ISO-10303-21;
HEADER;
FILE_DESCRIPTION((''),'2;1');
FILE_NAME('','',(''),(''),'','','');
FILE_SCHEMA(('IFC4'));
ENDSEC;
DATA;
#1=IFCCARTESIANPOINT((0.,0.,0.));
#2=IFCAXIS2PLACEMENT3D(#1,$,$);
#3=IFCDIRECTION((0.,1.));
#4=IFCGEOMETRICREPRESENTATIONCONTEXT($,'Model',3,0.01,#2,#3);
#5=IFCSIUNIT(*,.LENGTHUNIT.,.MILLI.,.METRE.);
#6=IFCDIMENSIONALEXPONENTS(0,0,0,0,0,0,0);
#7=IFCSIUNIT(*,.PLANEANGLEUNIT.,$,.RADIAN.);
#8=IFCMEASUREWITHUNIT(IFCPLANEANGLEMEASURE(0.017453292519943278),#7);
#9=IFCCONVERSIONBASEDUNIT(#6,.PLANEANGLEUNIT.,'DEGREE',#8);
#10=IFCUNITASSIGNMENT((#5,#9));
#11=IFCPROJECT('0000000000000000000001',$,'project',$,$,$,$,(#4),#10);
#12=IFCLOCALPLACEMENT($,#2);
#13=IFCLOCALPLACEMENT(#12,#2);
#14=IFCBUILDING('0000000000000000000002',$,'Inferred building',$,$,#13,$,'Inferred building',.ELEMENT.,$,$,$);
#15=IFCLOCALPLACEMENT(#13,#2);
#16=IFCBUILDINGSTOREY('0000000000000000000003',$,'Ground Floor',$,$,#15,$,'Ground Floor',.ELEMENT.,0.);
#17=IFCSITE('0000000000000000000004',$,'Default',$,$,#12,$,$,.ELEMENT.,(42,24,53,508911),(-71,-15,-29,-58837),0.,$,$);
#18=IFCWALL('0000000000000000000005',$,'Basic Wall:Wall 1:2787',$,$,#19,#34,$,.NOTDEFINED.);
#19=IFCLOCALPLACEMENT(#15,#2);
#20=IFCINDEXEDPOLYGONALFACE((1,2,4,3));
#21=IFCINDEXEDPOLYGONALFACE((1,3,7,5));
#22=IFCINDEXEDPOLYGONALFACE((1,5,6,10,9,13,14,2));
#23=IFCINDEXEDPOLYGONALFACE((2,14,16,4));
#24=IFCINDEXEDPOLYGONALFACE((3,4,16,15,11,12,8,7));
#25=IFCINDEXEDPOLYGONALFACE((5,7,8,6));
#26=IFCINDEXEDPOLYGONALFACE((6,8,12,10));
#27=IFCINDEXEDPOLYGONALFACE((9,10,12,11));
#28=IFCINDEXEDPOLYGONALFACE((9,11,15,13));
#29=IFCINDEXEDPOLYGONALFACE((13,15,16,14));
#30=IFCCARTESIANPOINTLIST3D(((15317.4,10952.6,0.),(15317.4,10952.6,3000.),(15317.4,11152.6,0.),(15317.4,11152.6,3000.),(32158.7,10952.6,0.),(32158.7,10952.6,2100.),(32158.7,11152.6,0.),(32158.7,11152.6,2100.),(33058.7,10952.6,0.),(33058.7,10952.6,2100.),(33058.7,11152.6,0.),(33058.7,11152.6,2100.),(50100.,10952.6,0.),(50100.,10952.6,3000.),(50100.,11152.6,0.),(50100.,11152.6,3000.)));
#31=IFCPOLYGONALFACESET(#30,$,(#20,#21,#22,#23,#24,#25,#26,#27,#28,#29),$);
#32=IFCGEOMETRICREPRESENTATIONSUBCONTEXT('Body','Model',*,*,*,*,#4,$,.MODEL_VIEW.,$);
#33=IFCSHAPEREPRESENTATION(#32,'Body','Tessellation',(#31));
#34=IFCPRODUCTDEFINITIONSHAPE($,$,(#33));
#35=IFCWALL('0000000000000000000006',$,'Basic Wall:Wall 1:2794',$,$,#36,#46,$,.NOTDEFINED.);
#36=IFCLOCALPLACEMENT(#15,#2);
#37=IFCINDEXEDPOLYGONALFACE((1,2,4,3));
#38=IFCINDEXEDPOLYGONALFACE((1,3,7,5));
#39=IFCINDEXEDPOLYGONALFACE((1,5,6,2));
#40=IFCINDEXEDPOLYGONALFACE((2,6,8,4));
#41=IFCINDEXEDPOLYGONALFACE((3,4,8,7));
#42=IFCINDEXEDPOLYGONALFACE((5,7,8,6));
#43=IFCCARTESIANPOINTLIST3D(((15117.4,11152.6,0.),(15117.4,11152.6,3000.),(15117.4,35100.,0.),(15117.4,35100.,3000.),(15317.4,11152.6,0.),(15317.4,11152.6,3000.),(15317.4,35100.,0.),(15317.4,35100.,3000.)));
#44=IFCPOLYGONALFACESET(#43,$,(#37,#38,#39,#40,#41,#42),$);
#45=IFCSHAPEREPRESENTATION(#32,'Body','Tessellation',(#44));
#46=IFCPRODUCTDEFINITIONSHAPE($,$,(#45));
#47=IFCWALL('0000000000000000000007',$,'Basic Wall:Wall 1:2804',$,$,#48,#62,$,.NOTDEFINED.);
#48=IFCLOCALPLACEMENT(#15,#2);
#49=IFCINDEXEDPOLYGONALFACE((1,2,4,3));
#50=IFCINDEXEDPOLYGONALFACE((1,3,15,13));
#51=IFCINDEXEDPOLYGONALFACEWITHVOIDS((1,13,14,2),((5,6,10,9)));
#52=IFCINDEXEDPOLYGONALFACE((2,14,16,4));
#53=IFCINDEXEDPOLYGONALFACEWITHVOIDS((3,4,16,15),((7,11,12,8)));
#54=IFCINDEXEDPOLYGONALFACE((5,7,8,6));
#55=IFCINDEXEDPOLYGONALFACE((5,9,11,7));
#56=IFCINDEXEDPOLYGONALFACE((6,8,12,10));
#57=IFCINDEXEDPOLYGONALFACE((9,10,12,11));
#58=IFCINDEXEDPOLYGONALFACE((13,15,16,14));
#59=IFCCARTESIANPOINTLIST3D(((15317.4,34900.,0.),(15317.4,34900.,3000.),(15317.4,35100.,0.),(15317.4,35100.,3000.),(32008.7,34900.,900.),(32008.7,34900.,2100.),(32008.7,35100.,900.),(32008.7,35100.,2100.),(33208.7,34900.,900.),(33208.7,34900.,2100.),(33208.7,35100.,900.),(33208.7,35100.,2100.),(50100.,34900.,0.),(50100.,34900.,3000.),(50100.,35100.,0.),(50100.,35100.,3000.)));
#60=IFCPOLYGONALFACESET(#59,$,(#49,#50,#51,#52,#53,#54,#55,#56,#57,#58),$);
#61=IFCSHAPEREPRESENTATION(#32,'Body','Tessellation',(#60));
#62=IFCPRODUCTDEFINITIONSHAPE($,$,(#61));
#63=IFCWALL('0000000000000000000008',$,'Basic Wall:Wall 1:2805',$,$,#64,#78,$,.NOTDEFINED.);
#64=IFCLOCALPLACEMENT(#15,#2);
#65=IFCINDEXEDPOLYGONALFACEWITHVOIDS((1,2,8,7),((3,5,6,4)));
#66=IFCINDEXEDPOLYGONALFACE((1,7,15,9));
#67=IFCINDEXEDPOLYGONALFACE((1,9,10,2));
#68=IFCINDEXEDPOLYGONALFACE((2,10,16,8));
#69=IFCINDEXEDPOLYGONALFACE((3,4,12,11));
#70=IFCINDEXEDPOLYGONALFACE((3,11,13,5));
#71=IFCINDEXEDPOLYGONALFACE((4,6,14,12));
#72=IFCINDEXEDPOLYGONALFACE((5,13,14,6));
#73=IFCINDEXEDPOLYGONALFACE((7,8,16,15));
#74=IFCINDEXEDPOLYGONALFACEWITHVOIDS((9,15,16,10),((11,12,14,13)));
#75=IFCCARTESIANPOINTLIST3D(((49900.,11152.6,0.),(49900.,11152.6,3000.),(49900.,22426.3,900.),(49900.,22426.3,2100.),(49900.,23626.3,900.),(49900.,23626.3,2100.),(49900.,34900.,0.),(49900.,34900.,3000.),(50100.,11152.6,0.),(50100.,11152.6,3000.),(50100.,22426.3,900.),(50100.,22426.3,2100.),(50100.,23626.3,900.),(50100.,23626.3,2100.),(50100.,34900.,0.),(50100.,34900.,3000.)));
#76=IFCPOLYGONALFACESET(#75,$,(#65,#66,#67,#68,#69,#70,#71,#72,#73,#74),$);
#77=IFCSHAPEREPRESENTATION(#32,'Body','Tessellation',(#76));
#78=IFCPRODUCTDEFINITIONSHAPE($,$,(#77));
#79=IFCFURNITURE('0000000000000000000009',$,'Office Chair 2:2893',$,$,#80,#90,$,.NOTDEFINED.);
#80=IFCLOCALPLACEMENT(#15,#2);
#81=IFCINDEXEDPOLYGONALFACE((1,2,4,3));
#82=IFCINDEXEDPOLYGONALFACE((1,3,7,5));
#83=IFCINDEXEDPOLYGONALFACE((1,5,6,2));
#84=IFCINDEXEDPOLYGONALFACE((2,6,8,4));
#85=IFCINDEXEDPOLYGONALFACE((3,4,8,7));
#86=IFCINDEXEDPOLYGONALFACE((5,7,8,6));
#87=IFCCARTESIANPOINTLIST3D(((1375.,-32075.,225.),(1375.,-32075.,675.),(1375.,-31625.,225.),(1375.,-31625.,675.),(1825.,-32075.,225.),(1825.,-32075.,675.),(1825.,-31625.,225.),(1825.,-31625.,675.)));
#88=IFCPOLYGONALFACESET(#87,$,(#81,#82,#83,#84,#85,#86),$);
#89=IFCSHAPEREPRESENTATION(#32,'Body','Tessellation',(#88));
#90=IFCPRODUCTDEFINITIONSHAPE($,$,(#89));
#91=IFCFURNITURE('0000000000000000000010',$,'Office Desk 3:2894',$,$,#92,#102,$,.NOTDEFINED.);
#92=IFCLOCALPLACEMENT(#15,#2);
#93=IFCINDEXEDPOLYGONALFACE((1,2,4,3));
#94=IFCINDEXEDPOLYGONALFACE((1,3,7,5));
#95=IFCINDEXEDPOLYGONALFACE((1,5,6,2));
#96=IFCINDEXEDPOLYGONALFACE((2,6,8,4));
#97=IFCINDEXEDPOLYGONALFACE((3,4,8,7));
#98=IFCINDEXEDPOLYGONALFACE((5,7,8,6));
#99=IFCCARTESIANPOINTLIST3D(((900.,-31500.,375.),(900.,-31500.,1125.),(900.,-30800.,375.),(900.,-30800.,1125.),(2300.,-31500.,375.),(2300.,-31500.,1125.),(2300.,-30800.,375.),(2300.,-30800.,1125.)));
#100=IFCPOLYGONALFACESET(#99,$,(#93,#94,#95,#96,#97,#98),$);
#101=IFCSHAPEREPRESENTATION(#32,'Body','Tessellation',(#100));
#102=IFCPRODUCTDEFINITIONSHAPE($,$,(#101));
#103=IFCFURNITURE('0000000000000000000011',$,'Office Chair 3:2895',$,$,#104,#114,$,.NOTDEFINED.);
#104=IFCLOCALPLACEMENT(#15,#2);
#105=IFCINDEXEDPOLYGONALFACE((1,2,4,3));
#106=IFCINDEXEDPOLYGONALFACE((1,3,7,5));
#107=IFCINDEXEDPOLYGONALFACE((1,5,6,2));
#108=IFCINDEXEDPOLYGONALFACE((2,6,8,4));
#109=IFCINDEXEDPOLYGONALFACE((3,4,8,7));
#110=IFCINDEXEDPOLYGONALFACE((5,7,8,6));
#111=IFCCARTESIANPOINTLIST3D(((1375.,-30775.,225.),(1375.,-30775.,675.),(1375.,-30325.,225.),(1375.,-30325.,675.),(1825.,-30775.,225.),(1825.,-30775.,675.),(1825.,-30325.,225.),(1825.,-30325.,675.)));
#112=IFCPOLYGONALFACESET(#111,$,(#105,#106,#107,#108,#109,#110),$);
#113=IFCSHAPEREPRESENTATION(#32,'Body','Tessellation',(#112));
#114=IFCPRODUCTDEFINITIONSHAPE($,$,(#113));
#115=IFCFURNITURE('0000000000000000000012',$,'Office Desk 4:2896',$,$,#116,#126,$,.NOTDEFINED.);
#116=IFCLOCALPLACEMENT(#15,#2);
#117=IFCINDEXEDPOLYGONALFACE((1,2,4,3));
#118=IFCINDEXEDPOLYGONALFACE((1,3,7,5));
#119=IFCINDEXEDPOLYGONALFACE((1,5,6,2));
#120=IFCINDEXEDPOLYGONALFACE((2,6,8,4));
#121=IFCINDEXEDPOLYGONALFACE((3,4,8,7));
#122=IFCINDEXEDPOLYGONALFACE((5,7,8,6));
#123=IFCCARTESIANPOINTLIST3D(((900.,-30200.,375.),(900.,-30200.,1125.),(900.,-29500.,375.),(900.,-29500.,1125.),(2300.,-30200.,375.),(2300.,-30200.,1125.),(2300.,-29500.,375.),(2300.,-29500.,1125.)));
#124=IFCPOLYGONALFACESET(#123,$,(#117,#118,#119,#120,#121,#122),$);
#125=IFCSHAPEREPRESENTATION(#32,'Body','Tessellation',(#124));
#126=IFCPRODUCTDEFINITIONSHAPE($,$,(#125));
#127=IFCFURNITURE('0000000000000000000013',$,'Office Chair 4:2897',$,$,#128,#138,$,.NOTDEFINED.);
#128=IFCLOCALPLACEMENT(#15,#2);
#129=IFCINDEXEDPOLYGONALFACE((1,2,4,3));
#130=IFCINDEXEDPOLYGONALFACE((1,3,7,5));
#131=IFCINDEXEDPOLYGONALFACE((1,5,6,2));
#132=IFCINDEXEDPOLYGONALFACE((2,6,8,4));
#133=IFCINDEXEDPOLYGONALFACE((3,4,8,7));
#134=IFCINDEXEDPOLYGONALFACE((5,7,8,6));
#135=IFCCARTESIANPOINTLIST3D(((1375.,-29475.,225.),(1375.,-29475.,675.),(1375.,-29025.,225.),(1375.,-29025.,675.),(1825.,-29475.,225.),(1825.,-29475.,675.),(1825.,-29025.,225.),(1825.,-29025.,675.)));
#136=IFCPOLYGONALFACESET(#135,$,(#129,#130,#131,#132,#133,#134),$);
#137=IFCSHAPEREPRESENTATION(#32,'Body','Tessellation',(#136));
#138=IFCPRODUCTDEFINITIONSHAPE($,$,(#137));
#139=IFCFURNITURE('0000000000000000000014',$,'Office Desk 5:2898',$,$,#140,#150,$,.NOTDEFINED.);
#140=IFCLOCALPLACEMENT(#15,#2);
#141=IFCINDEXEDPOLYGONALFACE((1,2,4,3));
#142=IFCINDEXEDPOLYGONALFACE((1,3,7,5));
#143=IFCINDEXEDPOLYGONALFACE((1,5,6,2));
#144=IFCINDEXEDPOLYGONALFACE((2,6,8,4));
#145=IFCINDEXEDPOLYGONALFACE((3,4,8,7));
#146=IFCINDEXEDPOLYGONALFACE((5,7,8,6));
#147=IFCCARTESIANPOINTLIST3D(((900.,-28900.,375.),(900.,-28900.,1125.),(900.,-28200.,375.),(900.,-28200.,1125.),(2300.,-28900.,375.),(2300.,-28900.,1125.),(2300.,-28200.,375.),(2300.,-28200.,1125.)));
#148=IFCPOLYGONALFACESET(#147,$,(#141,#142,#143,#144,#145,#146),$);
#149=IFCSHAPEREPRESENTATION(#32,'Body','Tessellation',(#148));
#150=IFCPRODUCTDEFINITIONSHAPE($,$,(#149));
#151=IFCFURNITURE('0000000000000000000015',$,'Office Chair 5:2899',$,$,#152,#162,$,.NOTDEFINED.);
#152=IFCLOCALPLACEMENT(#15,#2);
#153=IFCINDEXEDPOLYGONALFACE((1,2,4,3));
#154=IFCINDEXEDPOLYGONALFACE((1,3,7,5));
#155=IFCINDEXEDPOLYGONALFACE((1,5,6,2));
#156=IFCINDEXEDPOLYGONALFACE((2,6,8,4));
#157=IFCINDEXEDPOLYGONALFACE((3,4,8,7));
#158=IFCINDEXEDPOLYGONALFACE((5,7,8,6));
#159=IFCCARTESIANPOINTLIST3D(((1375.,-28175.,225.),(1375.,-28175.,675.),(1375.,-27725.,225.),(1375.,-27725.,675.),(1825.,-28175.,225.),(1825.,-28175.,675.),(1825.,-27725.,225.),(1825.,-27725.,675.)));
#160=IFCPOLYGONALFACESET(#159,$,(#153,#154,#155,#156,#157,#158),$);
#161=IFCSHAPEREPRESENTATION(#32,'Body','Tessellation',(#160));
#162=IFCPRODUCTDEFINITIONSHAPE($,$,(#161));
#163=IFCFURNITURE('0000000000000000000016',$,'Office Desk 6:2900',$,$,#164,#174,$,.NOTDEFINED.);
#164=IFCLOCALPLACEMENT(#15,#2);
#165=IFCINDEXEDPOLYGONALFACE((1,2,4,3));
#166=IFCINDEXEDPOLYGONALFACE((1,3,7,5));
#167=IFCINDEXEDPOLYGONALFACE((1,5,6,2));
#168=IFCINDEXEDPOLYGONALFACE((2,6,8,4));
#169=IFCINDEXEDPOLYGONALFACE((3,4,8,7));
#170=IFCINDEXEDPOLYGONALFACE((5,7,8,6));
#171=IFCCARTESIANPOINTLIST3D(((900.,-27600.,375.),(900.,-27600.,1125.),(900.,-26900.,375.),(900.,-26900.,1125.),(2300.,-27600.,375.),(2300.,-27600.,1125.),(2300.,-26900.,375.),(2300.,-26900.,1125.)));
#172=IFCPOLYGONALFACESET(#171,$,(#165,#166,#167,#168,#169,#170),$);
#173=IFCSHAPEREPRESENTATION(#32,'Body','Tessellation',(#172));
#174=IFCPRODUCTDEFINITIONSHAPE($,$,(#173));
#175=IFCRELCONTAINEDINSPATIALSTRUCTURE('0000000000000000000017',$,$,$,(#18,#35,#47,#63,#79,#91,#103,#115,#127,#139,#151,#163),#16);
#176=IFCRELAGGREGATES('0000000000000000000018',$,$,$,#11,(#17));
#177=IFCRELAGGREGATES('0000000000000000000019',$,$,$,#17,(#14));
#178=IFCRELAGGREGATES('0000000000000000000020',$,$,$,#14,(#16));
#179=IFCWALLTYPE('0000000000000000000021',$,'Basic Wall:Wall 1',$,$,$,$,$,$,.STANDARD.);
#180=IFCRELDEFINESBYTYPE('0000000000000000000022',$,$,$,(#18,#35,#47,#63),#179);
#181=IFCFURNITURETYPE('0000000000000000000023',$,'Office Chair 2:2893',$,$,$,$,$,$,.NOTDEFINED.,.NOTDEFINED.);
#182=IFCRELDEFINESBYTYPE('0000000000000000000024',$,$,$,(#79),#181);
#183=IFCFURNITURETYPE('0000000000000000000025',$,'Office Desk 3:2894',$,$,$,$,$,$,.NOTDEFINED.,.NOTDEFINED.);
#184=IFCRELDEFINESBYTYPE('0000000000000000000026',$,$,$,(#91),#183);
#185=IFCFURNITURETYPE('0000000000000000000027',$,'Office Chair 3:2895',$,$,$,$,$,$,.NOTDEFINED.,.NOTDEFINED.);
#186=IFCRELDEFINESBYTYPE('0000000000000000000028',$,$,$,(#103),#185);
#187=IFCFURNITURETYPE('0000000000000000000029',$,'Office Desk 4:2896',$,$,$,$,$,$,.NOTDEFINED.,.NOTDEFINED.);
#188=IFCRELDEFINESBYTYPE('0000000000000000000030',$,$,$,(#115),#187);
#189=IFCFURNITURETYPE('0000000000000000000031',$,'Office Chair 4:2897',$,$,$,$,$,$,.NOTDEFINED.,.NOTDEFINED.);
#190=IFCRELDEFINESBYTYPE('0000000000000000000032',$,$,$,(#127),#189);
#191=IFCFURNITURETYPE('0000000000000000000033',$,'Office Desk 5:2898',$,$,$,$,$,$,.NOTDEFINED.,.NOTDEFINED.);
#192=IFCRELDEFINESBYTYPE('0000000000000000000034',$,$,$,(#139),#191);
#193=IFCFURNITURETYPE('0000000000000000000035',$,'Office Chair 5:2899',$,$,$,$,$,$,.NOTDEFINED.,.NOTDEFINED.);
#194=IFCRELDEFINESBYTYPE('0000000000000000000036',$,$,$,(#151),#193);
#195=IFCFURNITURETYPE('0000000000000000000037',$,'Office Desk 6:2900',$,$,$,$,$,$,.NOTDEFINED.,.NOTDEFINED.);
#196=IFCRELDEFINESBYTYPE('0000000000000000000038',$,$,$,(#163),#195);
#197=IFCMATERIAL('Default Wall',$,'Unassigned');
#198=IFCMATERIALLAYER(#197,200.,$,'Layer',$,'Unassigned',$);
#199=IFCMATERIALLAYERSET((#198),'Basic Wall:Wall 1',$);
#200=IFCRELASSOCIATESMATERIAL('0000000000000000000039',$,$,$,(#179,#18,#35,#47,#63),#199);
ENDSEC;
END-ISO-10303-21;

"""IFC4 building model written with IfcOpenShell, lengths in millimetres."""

from ifc_helpers import new_model, entity, si_unit, converted_unit, direction, frame, frame_2d, origin, origin_2d_with_axis, place, context, subcontext, project, spatial, rectangle, extrude, material, layer, layer_set, layer_usage, type_object, element, save


model = new_model("IFC4")

# Units and contexts
model_context = context("Model", 3, precision=0.01, world=origin(), true_north=direction((0.0, 1.0)))
body_context = subcontext(model_context, "Body", "Model", "MODEL_VIEW")
ifc_project = project(units=[si_unit("LENGTHUNIT", "METRE", prefix="MILLI"), converted_unit("PLANEANGLEUNIT", "DEGREE", entity("IfcPlaneAngleMeasure", 0.017453292519943278), si_unit("PLANEANGLEUNIT", "RADIAN"), dimensions=[0, 0, 0, 0, 0, 0, 0])], contexts=[model_context])

# Site, building, storey
site_placement = place(None, origin())
site = spatial("IfcSite", under=ifc_project, at=site_placement, Name="Default", CompositionType="ELEMENT", RefLatitude=(42, 24, 53, 508911), RefLongitude=(-71, -15, -29, -58837), RefElevation=0.0)
building_placement = place(site_placement, origin())
building = spatial("IfcBuilding", under=site, at=building_placement, Name="Inferred building", LongName="Inferred building", CompositionType="ELEMENT")
storey_placement = place(building_placement, origin())
storey = spatial("IfcBuildingStorey", under=building, at=storey_placement, Name="Ground Floor", LongName="Ground Floor", CompositionType="ELEMENT", Elevation=0.0)

# Wall, opening
ifc_material = material(Name="Default Wall", Category="Unassigned")
ifc_layer = layer(ifc_material, 200.0, Name="Layer", Category="Unassigned")
ifc_layer_set = layer_set([ifc_layer], Name="Basic Wall:Wall 1")
ifc_layer_usage_1 = layer_usage(ifc_layer_set, "AXIS2", "NEGATIVE", 100.0)
wall_type = type_object("IfcWallType", Name="Basic Wall:Wall 1", PredefinedType="STANDARD", material=ifc_layer_set)
wall_1_placement = place(storey_placement, frame((15317.4, 11052.6, 0.0)))
wall_1 = element("IfcWall", 1, at=wall_1_placement, inside=storey, type_object=wall_type, material=ifc_layer_usage_1, Name="Basic Wall:Wall 1:2787", PredefinedType="NOTDEFINED", context=body_context, shape_type="SweptSolid", body=[
    extrude(rectangle(XDim=34782.6, YDim=200.0, at=frame_2d((17391.3, 0.0), x_axis=(1.0, 0.0))), origin(), (0.0, 0.0, 1.0), 3000.0),
])
opening_1_placement = place(wall_1_placement, origin())
element("IfcOpeningElement", 2, at=opening_1_placement, cuts=wall_1, PredefinedType="OPENING", context=body_context, shape_type="SweptSolid", body=[
    extrude(rectangle(XDim=2100.0, YDim=900.0, at=frame_2d((0.0, 0.0), x_axis=(1.0, 0.0))), frame((17291.3, -100.0, 1050.0), z_axis=(0.0, 1.0, 0.0), x_axis=(0.0, 0.0, -1.0)), (0.0, 0.0, 1.0), 200.0),
])

# Wall
ifc_layer_usage_2 = layer_usage(ifc_layer_set, "AXIS2", "NEGATIVE", 100.0)
wall_2_placement = place(storey_placement, frame((15217.4, 11152.6, 0.0), z_axis=(0.0, 0.0, 1.0), x_axis=(0.0, 1.0, 0.0)))
element("IfcWall", 3, at=wall_2_placement, inside=storey, type_object=wall_type, material=ifc_layer_usage_2, Name="Basic Wall:Wall 1:2794", PredefinedType="NOTDEFINED", context=body_context, shape_type="SweptSolid", body=[
    extrude(rectangle(XDim=23947.4, YDim=200.0, at=frame_2d((11973.7, 0.0), x_axis=(-1.0, 0.0))), origin(), (0.0, 0.0, 1.0), 3000.0),
])

# Walls, openings
ifc_layer_usage_3 = layer_usage(ifc_layer_set, "AXIS2", "NEGATIVE", 100.0)
wall_3_placement = place(storey_placement, frame((15317.4, 35000.0, 0.0)))
wall_3 = element("IfcWall", 4, at=wall_3_placement, inside=storey, type_object=wall_type, material=ifc_layer_usage_3, Name="Basic Wall:Wall 1:2804", PredefinedType="NOTDEFINED", context=body_context, shape_type="SweptSolid", body=[
    extrude(rectangle(XDim=34782.6, YDim=200.0, at=frame_2d((17391.3, 0.0), x_axis=(-1.0, 0.0))), origin(), (0.0, 0.0, 1.0), 3000.0),
])
opening_2_placement = place(wall_3_placement, origin())
element("IfcOpeningElement", 5, at=opening_2_placement, cuts=wall_3, PredefinedType="OPENING", context=body_context, shape_type="SweptSolid", body=[
    extrude(rectangle(XDim=1200.0, YDim=1200.0, at=frame_2d((0.0, 0.0), x_axis=(1.0, 0.0))), frame((17291.3, -100.0, 1500.0), z_axis=(0.0, 1.0, 0.0), x_axis=(0.0, 0.0, -1.0)), (0.0, 0.0, 1.0), 200.0),
])
ifc_layer_usage_4 = layer_usage(ifc_layer_set, "AXIS2", "NEGATIVE", 100.0)
wall_4_placement = place(storey_placement, frame((50000.0, 11152.6, 0.0), z_axis=(0.0, 0.0, 1.0), x_axis=(0.0, 1.0, 0.0)))
wall_4 = element("IfcWall", 6, at=wall_4_placement, inside=storey, type_object=wall_type, material=ifc_layer_usage_4, Name="Basic Wall:Wall 1:2805", PredefinedType="NOTDEFINED", context=body_context, shape_type="SweptSolid", body=[
    extrude(rectangle(XDim=23747.4, YDim=200.0, at=frame_2d((11873.7, 0.0), x_axis=(-1.0, 0.0))), origin(), (0.0, 0.0, 1.0), 3000.0),
])
opening_3_placement = place(wall_4_placement, origin())
element("IfcOpeningElement", 7, at=opening_3_placement, cuts=wall_4, PredefinedType="OPENING", context=body_context, shape_type="SweptSolid", body=[
    extrude(rectangle(XDim=1200.0, YDim=1200.0, at=frame_2d((0.0, 0.0), x_axis=(1.0, 0.0))), frame((11873.7, -100.0, 1500.0), z_axis=(0.0, 1.0, 0.0), x_axis=(0.0, 0.0, -1.0)), (0.0, 0.0, 1.0), 200.0),
])

# Furniture
furniture_type_1 = type_object("IfcFurnitureType", Name="Office Chair 2:2893", PredefinedType="NOTDEFINED")
furniture_1_placement = place(storey_placement, origin())
element("IfcFurniture", 8, at=furniture_1_placement, inside=storey, type_object=furniture_type_1, Name="Office Chair 2:2893", PredefinedType="NOTDEFINED", context=body_context, shape_type="SweptSolid", body=[
    extrude(rectangle(XDim=450.0, YDim=450.0, at=origin_2d_with_axis()), frame((1600.0, -31850.0, 225.0)), (0.0, 0.0, 1.0), 450.0),
])
furniture_type_2 = type_object("IfcFurnitureType", Name="Office Desk 3:2894", PredefinedType="NOTDEFINED")
furniture_2_placement = place(storey_placement, origin())
element("IfcFurniture", 9, at=furniture_2_placement, inside=storey, type_object=furniture_type_2, Name="Office Desk 3:2894", PredefinedType="NOTDEFINED", context=body_context, shape_type="SweptSolid", body=[
    extrude(rectangle(XDim=1400.0, YDim=700.0, at=origin_2d_with_axis()), frame((1600.0, -31150.0, 375.0)), (0.0, 0.0, 1.0), 750.0),
])
furniture_type_3 = type_object("IfcFurnitureType", Name="Office Chair 3:2895", PredefinedType="NOTDEFINED")
furniture_3_placement = place(storey_placement, origin())
element("IfcFurniture", 10, at=furniture_3_placement, inside=storey, type_object=furniture_type_3, Name="Office Chair 3:2895", PredefinedType="NOTDEFINED", context=body_context, shape_type="SweptSolid", body=[
    extrude(rectangle(XDim=450.0, YDim=450.0, at=origin_2d_with_axis()), frame((1600.0, -30550.0, 225.0)), (0.0, 0.0, 1.0), 450.0),
])
furniture_type_4 = type_object("IfcFurnitureType", Name="Office Desk 4:2896", PredefinedType="NOTDEFINED")
furniture_4_placement = place(storey_placement, origin())
element("IfcFurniture", 11, at=furniture_4_placement, inside=storey, type_object=furniture_type_4, Name="Office Desk 4:2896", PredefinedType="NOTDEFINED", context=body_context, shape_type="SweptSolid", body=[
    extrude(rectangle(XDim=1400.0, YDim=700.0, at=origin_2d_with_axis()), frame((1600.0, -29850.0, 375.0)), (0.0, 0.0, 1.0), 750.0),
])
furniture_type_5 = type_object("IfcFurnitureType", Name="Office Chair 4:2897", PredefinedType="NOTDEFINED")
furniture_5_placement = place(storey_placement, origin())
element("IfcFurniture", 12, at=furniture_5_placement, inside=storey, type_object=furniture_type_5, Name="Office Chair 4:2897", PredefinedType="NOTDEFINED", context=body_context, shape_type="SweptSolid", body=[
    extrude(rectangle(XDim=450.0, YDim=450.0, at=origin_2d_with_axis()), frame((1600.0, -29250.0, 225.0)), (0.0, 0.0, 1.0), 450.0),
])
furniture_type_6 = type_object("IfcFurnitureType", Name="Office Desk 5:2898", PredefinedType="NOTDEFINED")
furniture_6_placement = place(storey_placement, origin())
element("IfcFurniture", 13, at=furniture_6_placement, inside=storey, type_object=furniture_type_6, Name="Office Desk 5:2898", PredefinedType="NOTDEFINED", context=body_context, shape_type="SweptSolid", body=[
    extrude(rectangle(XDim=1400.0, YDim=700.0, at=origin_2d_with_axis()), frame((1600.0, -28550.0, 375.0)), (0.0, 0.0, 1.0), 750.0),
])
furniture_type_7 = type_object("IfcFurnitureType", Name="Office Chair 5:2899", PredefinedType="NOTDEFINED")
furniture_7_placement = place(storey_placement, origin())
element("IfcFurniture", 14, at=furniture_7_placement, inside=storey, type_object=furniture_type_7, Name="Office Chair 5:2899", PredefinedType="NOTDEFINED", context=body_context, shape_type="SweptSolid", body=[
    extrude(rectangle(XDim=450.0, YDim=450.0, at=origin_2d_with_axis()), frame((1600.0, -27950.0, 225.0)), (0.0, 0.0, 1.0), 450.0),
])
furniture_type_8 = type_object("IfcFurnitureType", Name="Office Desk 6:2900", PredefinedType="NOTDEFINED")
furniture_8_placement = place(storey_placement, origin())
element("IfcFurniture", 15, at=furniture_8_placement, inside=storey, type_object=furniture_type_8, Name="Office Desk 6:2900", PredefinedType="NOTDEFINED", context=body_context, shape_type="SweptSolid", body=[
    extrude(rectangle(XDim=1400.0, YDim=700.0, at=origin_2d_with_axis()), frame((1600.0, -27250.0, 375.0)), (0.0, 0.0, 1.0), 750.0),
])

save(model, "model.ifc")
